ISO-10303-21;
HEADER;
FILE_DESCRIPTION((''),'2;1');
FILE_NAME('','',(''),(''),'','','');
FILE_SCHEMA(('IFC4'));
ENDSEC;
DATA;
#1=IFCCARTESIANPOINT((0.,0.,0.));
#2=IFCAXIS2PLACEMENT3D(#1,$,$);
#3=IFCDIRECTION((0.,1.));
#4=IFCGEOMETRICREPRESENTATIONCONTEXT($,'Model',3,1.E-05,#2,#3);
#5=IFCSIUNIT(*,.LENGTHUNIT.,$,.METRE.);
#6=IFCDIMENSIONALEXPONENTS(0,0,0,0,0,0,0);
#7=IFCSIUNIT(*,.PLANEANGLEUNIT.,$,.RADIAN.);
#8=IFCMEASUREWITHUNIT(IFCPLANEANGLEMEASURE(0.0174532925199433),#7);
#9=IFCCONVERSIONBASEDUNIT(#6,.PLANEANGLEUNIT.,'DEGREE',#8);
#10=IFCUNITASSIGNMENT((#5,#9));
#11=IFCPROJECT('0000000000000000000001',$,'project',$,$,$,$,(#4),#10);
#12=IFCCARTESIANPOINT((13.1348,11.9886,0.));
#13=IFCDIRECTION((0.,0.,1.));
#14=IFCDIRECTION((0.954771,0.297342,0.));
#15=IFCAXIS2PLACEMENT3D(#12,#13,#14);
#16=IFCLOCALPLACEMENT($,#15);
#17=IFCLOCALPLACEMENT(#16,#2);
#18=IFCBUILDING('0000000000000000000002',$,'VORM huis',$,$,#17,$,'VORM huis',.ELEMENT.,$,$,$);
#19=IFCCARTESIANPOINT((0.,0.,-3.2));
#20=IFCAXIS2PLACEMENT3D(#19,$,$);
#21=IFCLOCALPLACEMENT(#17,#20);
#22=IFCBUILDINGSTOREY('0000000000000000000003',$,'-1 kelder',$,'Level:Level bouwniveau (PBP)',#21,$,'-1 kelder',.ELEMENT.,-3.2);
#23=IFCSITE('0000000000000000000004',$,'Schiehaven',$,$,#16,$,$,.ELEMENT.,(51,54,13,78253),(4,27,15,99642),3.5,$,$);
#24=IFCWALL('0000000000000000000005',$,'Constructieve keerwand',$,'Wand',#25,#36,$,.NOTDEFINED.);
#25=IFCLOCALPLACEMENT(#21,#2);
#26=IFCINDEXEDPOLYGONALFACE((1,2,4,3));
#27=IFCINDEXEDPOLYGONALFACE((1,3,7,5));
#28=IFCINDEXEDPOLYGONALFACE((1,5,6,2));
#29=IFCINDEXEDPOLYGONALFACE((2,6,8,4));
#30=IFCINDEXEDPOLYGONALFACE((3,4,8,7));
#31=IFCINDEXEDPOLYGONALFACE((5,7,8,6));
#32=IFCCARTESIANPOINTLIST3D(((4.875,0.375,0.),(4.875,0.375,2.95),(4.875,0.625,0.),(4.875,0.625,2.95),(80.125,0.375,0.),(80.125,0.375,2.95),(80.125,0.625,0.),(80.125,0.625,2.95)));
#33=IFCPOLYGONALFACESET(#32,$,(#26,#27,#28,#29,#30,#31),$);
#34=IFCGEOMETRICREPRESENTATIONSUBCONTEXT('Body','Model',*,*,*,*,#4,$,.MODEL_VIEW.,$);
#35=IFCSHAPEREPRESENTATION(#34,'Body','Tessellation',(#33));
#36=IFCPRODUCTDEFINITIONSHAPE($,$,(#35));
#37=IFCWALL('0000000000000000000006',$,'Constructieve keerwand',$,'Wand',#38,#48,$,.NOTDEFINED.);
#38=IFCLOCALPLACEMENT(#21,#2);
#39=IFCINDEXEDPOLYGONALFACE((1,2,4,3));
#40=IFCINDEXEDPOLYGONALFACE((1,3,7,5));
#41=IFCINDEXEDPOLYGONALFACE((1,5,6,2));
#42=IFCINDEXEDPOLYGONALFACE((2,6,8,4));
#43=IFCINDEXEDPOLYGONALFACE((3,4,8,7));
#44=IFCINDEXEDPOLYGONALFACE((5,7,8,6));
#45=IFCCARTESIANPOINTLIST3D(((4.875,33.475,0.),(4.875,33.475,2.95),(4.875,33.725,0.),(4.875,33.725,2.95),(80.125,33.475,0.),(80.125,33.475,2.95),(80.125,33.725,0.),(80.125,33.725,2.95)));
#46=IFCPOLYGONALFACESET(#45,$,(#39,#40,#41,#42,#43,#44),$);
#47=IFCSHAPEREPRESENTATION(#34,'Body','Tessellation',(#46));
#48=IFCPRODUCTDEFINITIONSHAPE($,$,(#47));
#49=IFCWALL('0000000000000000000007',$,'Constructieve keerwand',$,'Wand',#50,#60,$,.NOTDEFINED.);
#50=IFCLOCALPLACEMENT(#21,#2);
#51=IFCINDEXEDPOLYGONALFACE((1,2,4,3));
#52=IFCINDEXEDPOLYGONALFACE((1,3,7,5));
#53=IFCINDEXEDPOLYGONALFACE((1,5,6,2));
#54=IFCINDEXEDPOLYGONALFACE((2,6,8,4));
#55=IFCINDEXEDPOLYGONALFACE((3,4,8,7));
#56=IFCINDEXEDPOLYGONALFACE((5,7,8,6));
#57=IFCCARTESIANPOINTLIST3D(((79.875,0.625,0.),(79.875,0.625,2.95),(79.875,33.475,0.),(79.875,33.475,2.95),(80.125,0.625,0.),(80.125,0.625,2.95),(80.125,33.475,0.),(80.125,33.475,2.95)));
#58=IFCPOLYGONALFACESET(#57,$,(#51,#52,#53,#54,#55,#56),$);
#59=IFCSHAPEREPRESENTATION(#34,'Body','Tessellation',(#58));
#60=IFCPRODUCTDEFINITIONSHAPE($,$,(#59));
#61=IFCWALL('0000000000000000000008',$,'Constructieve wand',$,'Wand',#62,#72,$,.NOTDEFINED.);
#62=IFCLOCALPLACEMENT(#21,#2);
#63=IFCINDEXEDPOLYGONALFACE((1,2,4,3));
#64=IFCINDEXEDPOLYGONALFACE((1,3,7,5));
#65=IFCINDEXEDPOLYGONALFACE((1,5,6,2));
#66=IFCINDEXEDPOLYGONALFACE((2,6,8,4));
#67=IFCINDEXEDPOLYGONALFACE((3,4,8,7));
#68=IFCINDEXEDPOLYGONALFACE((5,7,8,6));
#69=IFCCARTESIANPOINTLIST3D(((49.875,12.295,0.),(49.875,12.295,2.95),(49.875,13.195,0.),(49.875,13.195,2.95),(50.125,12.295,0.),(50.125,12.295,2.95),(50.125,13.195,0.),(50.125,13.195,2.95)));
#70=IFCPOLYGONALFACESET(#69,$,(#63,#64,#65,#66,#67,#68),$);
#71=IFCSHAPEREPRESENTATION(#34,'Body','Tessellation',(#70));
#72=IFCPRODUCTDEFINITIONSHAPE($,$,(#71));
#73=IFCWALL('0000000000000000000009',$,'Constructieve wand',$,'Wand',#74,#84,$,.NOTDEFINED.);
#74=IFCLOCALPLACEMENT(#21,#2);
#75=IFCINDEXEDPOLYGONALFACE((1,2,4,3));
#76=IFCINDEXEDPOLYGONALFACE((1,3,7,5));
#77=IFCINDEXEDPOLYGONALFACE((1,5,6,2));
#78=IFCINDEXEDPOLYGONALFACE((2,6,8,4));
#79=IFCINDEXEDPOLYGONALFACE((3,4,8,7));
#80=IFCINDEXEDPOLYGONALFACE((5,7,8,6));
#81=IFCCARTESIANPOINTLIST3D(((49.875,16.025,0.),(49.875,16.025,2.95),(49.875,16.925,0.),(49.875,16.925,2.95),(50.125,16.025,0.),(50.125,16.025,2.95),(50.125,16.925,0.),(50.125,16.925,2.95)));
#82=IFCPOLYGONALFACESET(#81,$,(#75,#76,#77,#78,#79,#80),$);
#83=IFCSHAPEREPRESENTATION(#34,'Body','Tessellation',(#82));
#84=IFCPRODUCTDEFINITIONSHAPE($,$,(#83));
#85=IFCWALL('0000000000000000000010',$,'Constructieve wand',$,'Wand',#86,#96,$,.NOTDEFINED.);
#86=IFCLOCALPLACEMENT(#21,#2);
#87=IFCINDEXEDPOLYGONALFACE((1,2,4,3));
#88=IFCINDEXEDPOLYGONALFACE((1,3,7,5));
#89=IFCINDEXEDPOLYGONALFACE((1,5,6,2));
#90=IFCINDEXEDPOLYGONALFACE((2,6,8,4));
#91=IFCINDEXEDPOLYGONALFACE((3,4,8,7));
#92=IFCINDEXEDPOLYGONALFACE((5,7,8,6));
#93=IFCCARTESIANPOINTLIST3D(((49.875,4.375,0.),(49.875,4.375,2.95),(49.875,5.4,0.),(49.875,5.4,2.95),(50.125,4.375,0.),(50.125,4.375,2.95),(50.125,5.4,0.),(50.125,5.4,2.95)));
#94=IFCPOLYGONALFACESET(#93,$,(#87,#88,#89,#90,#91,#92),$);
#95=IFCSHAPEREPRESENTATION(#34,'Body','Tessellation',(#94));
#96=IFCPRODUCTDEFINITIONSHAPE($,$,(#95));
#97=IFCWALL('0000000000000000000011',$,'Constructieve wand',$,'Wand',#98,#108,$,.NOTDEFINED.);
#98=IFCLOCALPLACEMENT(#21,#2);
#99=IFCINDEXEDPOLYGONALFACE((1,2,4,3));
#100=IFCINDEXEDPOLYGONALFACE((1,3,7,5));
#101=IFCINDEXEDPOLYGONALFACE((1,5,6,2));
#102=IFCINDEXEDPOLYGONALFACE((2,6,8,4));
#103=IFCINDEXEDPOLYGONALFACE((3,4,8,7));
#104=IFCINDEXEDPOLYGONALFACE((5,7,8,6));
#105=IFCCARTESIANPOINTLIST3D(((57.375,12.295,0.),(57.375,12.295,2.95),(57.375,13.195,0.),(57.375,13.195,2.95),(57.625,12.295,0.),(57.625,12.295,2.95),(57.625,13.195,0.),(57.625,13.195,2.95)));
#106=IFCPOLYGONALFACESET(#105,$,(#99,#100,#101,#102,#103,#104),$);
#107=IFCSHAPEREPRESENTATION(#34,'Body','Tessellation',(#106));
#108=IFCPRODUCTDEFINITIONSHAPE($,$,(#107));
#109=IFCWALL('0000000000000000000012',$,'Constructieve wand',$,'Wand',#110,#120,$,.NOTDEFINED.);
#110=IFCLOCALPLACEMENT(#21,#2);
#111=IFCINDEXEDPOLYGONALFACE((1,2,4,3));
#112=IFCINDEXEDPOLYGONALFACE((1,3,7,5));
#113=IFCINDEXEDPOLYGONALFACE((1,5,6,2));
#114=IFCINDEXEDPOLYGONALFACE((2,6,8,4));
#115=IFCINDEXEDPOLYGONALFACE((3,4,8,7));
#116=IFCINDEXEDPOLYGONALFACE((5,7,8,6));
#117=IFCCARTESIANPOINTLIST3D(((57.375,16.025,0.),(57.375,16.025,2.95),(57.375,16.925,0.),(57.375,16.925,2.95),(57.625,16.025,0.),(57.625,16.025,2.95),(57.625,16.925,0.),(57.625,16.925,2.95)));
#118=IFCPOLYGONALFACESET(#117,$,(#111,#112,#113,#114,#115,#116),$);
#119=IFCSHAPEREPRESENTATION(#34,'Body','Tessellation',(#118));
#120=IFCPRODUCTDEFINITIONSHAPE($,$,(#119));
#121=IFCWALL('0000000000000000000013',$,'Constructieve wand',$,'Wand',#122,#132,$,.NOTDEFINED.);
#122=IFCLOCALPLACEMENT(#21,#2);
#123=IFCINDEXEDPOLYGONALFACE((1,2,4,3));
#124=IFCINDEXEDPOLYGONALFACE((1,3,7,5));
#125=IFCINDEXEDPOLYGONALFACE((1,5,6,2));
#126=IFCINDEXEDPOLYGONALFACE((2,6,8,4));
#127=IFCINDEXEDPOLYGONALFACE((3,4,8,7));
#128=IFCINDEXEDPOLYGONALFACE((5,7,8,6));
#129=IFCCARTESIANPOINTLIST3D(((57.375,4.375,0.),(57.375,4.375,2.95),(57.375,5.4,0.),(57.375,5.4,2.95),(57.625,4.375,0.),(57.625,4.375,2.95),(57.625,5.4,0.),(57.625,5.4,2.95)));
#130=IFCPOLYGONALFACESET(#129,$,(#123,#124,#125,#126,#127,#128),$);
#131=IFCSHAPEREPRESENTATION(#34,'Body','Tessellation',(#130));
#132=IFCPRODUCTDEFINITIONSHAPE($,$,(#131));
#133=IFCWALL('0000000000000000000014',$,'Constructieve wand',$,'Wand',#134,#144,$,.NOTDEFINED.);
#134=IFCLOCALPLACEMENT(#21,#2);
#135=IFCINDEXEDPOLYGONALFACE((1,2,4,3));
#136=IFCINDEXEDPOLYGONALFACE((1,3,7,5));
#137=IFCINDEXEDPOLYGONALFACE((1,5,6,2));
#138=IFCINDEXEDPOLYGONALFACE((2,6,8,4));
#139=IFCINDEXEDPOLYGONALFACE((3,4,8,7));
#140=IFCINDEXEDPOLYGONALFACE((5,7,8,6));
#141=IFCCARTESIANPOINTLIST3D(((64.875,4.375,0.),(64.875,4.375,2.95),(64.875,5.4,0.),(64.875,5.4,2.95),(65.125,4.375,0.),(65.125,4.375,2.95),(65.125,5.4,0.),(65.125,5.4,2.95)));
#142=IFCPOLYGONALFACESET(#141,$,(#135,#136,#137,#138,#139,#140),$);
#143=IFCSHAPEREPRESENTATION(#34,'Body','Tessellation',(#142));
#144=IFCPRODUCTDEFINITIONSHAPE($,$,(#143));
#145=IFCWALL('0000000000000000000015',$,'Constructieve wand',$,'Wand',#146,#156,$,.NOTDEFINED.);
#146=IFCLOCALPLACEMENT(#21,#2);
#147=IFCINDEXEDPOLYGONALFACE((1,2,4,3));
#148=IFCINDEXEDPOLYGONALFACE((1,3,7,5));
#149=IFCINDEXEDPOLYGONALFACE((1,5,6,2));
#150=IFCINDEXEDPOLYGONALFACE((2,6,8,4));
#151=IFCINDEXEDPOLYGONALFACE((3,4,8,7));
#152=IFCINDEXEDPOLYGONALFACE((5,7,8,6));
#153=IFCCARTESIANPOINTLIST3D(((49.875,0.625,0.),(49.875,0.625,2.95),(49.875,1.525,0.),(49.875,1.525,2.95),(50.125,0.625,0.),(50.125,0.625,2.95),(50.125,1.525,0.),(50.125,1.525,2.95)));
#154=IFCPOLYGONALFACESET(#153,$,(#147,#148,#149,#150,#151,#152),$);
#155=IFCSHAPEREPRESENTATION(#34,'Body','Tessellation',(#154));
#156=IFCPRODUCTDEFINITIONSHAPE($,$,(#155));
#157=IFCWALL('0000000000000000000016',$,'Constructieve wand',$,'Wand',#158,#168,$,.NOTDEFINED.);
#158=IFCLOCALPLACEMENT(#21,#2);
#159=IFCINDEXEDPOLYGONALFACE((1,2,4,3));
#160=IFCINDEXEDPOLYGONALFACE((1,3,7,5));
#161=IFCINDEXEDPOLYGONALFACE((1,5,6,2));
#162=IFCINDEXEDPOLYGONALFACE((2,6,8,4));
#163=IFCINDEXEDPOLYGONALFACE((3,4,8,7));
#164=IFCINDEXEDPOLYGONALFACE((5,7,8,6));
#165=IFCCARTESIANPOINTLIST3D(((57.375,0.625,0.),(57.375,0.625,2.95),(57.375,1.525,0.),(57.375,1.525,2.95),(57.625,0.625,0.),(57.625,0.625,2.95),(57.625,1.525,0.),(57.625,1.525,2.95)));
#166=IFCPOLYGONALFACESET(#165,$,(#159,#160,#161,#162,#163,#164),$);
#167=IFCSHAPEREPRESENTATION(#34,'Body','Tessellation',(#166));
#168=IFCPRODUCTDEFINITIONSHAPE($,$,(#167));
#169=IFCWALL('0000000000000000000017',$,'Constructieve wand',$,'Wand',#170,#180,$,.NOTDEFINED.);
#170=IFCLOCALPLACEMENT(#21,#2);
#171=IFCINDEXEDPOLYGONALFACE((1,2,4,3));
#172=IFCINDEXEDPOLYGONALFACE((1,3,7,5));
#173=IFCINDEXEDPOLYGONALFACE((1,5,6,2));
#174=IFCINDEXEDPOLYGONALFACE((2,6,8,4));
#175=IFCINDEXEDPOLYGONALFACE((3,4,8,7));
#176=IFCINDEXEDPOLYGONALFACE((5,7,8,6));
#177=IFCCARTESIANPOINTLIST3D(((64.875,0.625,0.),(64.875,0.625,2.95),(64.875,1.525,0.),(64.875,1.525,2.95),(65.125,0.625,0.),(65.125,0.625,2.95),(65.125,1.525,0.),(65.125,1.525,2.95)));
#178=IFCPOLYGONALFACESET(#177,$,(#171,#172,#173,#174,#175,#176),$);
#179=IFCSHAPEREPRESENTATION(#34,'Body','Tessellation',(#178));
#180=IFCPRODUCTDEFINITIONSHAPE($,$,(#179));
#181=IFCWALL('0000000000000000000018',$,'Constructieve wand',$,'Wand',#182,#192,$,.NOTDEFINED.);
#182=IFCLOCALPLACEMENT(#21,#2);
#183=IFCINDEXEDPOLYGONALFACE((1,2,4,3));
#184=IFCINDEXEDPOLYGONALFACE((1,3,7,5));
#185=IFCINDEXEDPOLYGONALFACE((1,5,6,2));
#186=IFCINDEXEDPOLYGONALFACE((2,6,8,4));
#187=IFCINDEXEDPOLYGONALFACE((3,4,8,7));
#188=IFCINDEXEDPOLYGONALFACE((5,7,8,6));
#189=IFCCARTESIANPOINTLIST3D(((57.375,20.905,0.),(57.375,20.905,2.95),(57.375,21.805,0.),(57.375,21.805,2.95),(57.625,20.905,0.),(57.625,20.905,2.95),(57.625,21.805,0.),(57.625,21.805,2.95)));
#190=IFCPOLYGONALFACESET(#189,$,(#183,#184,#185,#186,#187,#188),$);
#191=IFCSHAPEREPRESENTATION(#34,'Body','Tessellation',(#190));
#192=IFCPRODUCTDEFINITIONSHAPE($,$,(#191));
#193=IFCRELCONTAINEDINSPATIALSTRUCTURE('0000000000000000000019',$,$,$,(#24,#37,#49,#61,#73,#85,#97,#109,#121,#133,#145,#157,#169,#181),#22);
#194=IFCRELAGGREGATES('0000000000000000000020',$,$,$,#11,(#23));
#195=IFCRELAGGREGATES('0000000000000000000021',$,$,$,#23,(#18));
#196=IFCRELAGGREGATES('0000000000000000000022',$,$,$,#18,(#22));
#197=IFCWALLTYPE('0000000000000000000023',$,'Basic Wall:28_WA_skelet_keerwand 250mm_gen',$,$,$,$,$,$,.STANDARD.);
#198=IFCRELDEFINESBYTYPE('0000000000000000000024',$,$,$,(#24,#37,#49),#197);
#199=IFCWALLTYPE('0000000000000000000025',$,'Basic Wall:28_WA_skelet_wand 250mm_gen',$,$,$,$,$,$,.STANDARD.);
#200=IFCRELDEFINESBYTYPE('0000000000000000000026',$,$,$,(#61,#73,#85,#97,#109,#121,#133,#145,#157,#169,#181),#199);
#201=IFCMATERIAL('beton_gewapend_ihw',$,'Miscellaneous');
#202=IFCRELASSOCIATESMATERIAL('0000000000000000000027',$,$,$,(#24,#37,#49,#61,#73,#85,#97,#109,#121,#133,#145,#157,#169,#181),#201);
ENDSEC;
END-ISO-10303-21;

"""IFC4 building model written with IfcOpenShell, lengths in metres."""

from ifc_helpers import new_model, entity, si_unit, converted_unit, direction, frame, origin, place, context, subcontext, project, spatial, indexed_curve, outline, extrude, material, type_object, element, save


model = new_model("IFC4")

# Units and contexts
model_context = context("Model", 3, precision=1e-05, world=origin(), true_north=direction((0.0, 1.0)))
body_context = subcontext(model_context, "Body", "Model", "MODEL_VIEW")
ifc_project = project(units=[si_unit("LENGTHUNIT", "METRE"), converted_unit("PLANEANGLEUNIT", "DEGREE", entity("IfcPlaneAngleMeasure", 0.0174532925199433), si_unit("PLANEANGLEUNIT", "RADIAN"), dimensions=[0, 0, 0, 0, 0, 0, 0])], contexts=[model_context])

# Site, building, storey
site_placement = place(None, frame((13.1348, 11.9886, 0.0), z_axis=(0.0, 0.0, 1.0), x_axis=(0.954771, 0.297342, 0.0)))
site = spatial("IfcSite", under=ifc_project, at=site_placement, Name="Schiehaven", CompositionType="ELEMENT", RefLatitude=(51, 54, 13, 78253), RefLongitude=(4, 27, 15, 99642), RefElevation=3.5)
building_placement = place(site_placement, origin())
building = spatial("IfcBuilding", under=site, at=building_placement, Name="VORM huis", LongName="VORM huis", CompositionType="ELEMENT")
storey_placement = place(building_placement, frame((0.0, 0.0, -3.2)))
storey = spatial("IfcBuildingStorey", under=building, at=storey_placement, Name="-1 kelder", ObjectType="Level:Level bouwniveau (PBP)", LongName="-1 kelder", CompositionType="ELEMENT", Elevation=-3.2)

# Walls
ifc_material = material(Name="beton_gewapend_ihw", Category="Miscellaneous")
wall_type_1 = type_object("IfcWallType", Name="Basic Wall:28_WA_skelet_keerwand 250mm_gen", PredefinedType="STANDARD")
wall_1_placement = place(storey_placement, frame((80.125, 0.5, 0.0), z_axis=(0.0, 0.0, 1.0), x_axis=(-1.0, 0.0, 0.0)))
element("IfcWall", 1, at=wall_1_placement, inside=storey, type_object=wall_type_1, material=ifc_material, Name="Constructieve keerwand", ObjectType="Wand", PredefinedType="NOTDEFINED", context=body_context, shape_type="SweptSolid", body=[
    extrude(outline(indexed_curve([(75.25, 0.125), (0.0, 0.125), (0.0, -0.125), (75.25, -0.125), (75.25, 0.125)], self_intersect=False)), origin(), (0.0, 0.0, 1.0), 2.95),
])
wall_2_placement = place(storey_placement, frame((80.125, 33.6, 0.0), z_axis=(0.0, 0.0, 1.0), x_axis=(-1.0, 0.0, 0.0)))
element("IfcWall", 2, at=wall_2_placement, inside=storey, type_object=wall_type_1, material=ifc_material, Name="Constructieve keerwand", ObjectType="Wand", PredefinedType="NOTDEFINED", context=body_context, shape_type="SweptSolid", body=[
    extrude(outline(indexed_curve([(75.25, 0.125), (0.0, 0.125), (0.0, -0.125), (75.25, -0.125), (75.25, 0.125)], self_intersect=False)), origin(), (0.0, 0.0, 1.0), 2.95),
])
wall_3_placement = place(storey_placement, frame((80.0, 0.625, 0.0), z_axis=(0.0, 0.0, 1.0), x_axis=(0.0, 1.0, 0.0)))
element("IfcWall", 3, at=wall_3_placement, inside=storey, type_object=wall_type_1, material=ifc_material, Name="Constructieve keerwand", ObjectType="Wand", PredefinedType="NOTDEFINED", context=body_context, shape_type="SweptSolid", body=[
    extrude(outline(indexed_curve([(32.85, 0.125), (0.0, 0.125), (0.0, -0.125), (32.85, -0.125), (32.85, 0.125)], self_intersect=False)), origin(), (0.0, 0.0, 1.0), 2.95),
])
wall_type_2 = type_object("IfcWallType", Name="Basic Wall:28_WA_skelet_wand 250mm_gen", PredefinedType="STANDARD")
wall_4_placement = place(storey_placement, frame((50.0, 12.295, 0.0), z_axis=(0.0, 0.0, 1.0), x_axis=(0.0, 1.0, 0.0)))
element("IfcWall", 4, at=wall_4_placement, inside=storey, type_object=wall_type_2, material=ifc_material, Name="Constructieve wand", ObjectType="Wand", PredefinedType="NOTDEFINED", context=body_context, shape_type="SweptSolid", body=[
    extrude(outline(indexed_curve([(0.9, 0.125), (0.0, 0.125), (0.0, -0.125), (0.9, -0.125), (0.9, 0.125)], self_intersect=False)), origin(), (0.0, 0.0, 1.0), 2.95),
])
wall_5_placement = place(storey_placement, frame((50.0, 16.025, 0.0), z_axis=(0.0, 0.0, 1.0), x_axis=(0.0, 1.0, 0.0)))
element("IfcWall", 5, at=wall_5_placement, inside=storey, type_object=wall_type_2, material=ifc_material, Name="Constructieve wand", ObjectType="Wand", PredefinedType="NOTDEFINED", context=body_context, shape_type="SweptSolid", body=[
    extrude(outline(indexed_curve([(0.9, 0.125), (0.0, 0.125), (0.0, -0.125), (0.9, -0.125), (0.9, 0.125)], self_intersect=False)), origin(), (0.0, 0.0, 1.0), 2.95),
])
wall_6_placement = place(storey_placement, frame((50.0, 4.375, 0.0), z_axis=(0.0, 0.0, 1.0), x_axis=(0.0, 1.0, 0.0)))
element("IfcWall", 6, at=wall_6_placement, inside=storey, type_object=wall_type_2, material=ifc_material, Name="Constructieve wand", ObjectType="Wand", PredefinedType="NOTDEFINED", context=body_context, shape_type="SweptSolid", body=[
    extrude(outline(indexed_curve([(1.025, 0.125), (0.0, 0.125), (0.0, -0.125), (1.025, -0.125), (1.025, 0.125)], self_intersect=False)), origin(), (0.0, 0.0, 1.0), 2.95),
])
wall_7_placement = place(storey_placement, frame((57.5, 12.295, 0.0), z_axis=(0.0, 0.0, 1.0), x_axis=(0.0, 1.0, 0.0)))
element("IfcWall", 7, at=wall_7_placement, inside=storey, type_object=wall_type_2, material=ifc_material, Name="Constructieve wand", ObjectType="Wand", PredefinedType="NOTDEFINED", context=body_context, shape_type="SweptSolid", body=[
    extrude(outline(indexed_curve([(0.9, 0.125), (0.0, 0.125), (0.0, -0.125), (0.9, -0.125), (0.9, 0.125)], self_intersect=False)), origin(), (0.0, 0.0, 1.0), 2.95),
])
wall_8_placement = place(storey_placement, frame((57.5, 16.025, 0.0), z_axis=(0.0, 0.0, 1.0), x_axis=(0.0, 1.0, 0.0)))
element("IfcWall", 8, at=wall_8_placement, inside=storey, type_object=wall_type_2, material=ifc_material, Name="Constructieve wand", ObjectType="Wand", PredefinedType="NOTDEFINED", context=body_context, shape_type="SweptSolid", body=[
    extrude(outline(indexed_curve([(0.9, 0.125), (0.0, 0.125), (0.0, -0.125), (0.9, -0.125), (0.9, 0.125)], self_intersect=False)), origin(), (0.0, 0.0, 1.0), 2.95),
])
wall_9_placement = place(storey_placement, frame((57.5, 4.375, 0.0), z_axis=(0.0, 0.0, 1.0), x_axis=(0.0, 1.0, 0.0)))
element("IfcWall", 9, at=wall_9_placement, inside=storey, type_object=wall_type_2, material=ifc_material, Name="Constructieve wand", ObjectType="Wand", PredefinedType="NOTDEFINED", context=body_context, shape_type="SweptSolid", body=[
    extrude(outline(indexed_curve([(1.025, 0.125), (0.0, 0.125), (0.0, -0.125), (1.025, -0.125), (1.025, 0.125)], self_intersect=False)), origin(), (0.0, 0.0, 1.0), 2.95),
])
wall_10_placement = place(storey_placement, frame((65.0, 4.375, 0.0), z_axis=(0.0, 0.0, 1.0), x_axis=(0.0, 1.0, 0.0)))
element("IfcWall", 10, at=wall_10_placement, inside=storey, type_object=wall_type_2, material=ifc_material, Name="Constructieve wand", ObjectType="Wand", PredefinedType="NOTDEFINED", context=body_context, shape_type="SweptSolid", body=[
    extrude(outline(indexed_curve([(1.025, 0.125), (0.0, 0.125), (0.0, -0.125), (1.025, -0.125), (1.025, 0.125)], self_intersect=False)), origin(), (0.0, 0.0, 1.0), 2.95),
])
wall_11_placement = place(storey_placement, frame((50.0, 1.525, 0.0), z_axis=(0.0, 0.0, 1.0), x_axis=(0.0, -1.0, 0.0)))
element("IfcWall", 11, at=wall_11_placement, inside=storey, type_object=wall_type_2, material=ifc_material, Name="Constructieve wand", ObjectType="Wand", PredefinedType="NOTDEFINED", context=body_context, shape_type="SweptSolid", body=[
    extrude(outline(indexed_curve([(0.9, 0.125), (0.0, 0.125), (0.0, -0.125), (0.9, -0.125), (0.9, 0.125)], self_intersect=False)), origin(), (0.0, 0.0, 1.0), 2.95),
])
wall_12_placement = place(storey_placement, frame((57.5, 1.525, 0.0), z_axis=(0.0, 0.0, 1.0), x_axis=(0.0, -1.0, 0.0)))
element("IfcWall", 12, at=wall_12_placement, inside=storey, type_object=wall_type_2, material=ifc_material, Name="Constructieve wand", ObjectType="Wand", PredefinedType="NOTDEFINED", context=body_context, shape_type="SweptSolid", body=[
    extrude(outline(indexed_curve([(0.9, 0.125), (0.0, 0.125), (0.0, -0.125), (0.9, -0.125), (0.9, 0.125)], self_intersect=False)), origin(), (0.0, 0.0, 1.0), 2.95),
])
wall_13_placement = place(storey_placement, frame((65.0, 1.525, 0.0), z_axis=(0.0, 0.0, 1.0), x_axis=(0.0, -1.0, 0.0)))
element("IfcWall", 13, at=wall_13_placement, inside=storey, type_object=wall_type_2, material=ifc_material, Name="Constructieve wand", ObjectType="Wand", PredefinedType="NOTDEFINED", context=body_context, shape_type="SweptSolid", body=[
    extrude(outline(indexed_curve([(0.9, 0.125), (0.0, 0.125), (0.0, -0.125), (0.9, -0.125), (0.9, 0.125)], self_intersect=False)), origin(), (0.0, 0.0, 1.0), 2.95),
])
wall_14_placement = place(storey_placement, frame((57.5, 21.805, 0.0), z_axis=(0.0, 0.0, 1.0), x_axis=(0.0, -1.0, 0.0)))
element("IfcWall", 14, at=wall_14_placement, inside=storey, type_object=wall_type_2, material=ifc_material, Name="Constructieve wand", ObjectType="Wand", PredefinedType="NOTDEFINED", context=body_context, shape_type="SweptSolid", body=[
    extrude(outline(indexed_curve([(0.9, 0.125), (0.0, 0.125), (0.0, -0.125), (0.9, -0.125), (0.9, 0.125)], self_intersect=False)), origin(), (0.0, 0.0, 1.0), 2.95),
])

save(model, "model.ifc")
